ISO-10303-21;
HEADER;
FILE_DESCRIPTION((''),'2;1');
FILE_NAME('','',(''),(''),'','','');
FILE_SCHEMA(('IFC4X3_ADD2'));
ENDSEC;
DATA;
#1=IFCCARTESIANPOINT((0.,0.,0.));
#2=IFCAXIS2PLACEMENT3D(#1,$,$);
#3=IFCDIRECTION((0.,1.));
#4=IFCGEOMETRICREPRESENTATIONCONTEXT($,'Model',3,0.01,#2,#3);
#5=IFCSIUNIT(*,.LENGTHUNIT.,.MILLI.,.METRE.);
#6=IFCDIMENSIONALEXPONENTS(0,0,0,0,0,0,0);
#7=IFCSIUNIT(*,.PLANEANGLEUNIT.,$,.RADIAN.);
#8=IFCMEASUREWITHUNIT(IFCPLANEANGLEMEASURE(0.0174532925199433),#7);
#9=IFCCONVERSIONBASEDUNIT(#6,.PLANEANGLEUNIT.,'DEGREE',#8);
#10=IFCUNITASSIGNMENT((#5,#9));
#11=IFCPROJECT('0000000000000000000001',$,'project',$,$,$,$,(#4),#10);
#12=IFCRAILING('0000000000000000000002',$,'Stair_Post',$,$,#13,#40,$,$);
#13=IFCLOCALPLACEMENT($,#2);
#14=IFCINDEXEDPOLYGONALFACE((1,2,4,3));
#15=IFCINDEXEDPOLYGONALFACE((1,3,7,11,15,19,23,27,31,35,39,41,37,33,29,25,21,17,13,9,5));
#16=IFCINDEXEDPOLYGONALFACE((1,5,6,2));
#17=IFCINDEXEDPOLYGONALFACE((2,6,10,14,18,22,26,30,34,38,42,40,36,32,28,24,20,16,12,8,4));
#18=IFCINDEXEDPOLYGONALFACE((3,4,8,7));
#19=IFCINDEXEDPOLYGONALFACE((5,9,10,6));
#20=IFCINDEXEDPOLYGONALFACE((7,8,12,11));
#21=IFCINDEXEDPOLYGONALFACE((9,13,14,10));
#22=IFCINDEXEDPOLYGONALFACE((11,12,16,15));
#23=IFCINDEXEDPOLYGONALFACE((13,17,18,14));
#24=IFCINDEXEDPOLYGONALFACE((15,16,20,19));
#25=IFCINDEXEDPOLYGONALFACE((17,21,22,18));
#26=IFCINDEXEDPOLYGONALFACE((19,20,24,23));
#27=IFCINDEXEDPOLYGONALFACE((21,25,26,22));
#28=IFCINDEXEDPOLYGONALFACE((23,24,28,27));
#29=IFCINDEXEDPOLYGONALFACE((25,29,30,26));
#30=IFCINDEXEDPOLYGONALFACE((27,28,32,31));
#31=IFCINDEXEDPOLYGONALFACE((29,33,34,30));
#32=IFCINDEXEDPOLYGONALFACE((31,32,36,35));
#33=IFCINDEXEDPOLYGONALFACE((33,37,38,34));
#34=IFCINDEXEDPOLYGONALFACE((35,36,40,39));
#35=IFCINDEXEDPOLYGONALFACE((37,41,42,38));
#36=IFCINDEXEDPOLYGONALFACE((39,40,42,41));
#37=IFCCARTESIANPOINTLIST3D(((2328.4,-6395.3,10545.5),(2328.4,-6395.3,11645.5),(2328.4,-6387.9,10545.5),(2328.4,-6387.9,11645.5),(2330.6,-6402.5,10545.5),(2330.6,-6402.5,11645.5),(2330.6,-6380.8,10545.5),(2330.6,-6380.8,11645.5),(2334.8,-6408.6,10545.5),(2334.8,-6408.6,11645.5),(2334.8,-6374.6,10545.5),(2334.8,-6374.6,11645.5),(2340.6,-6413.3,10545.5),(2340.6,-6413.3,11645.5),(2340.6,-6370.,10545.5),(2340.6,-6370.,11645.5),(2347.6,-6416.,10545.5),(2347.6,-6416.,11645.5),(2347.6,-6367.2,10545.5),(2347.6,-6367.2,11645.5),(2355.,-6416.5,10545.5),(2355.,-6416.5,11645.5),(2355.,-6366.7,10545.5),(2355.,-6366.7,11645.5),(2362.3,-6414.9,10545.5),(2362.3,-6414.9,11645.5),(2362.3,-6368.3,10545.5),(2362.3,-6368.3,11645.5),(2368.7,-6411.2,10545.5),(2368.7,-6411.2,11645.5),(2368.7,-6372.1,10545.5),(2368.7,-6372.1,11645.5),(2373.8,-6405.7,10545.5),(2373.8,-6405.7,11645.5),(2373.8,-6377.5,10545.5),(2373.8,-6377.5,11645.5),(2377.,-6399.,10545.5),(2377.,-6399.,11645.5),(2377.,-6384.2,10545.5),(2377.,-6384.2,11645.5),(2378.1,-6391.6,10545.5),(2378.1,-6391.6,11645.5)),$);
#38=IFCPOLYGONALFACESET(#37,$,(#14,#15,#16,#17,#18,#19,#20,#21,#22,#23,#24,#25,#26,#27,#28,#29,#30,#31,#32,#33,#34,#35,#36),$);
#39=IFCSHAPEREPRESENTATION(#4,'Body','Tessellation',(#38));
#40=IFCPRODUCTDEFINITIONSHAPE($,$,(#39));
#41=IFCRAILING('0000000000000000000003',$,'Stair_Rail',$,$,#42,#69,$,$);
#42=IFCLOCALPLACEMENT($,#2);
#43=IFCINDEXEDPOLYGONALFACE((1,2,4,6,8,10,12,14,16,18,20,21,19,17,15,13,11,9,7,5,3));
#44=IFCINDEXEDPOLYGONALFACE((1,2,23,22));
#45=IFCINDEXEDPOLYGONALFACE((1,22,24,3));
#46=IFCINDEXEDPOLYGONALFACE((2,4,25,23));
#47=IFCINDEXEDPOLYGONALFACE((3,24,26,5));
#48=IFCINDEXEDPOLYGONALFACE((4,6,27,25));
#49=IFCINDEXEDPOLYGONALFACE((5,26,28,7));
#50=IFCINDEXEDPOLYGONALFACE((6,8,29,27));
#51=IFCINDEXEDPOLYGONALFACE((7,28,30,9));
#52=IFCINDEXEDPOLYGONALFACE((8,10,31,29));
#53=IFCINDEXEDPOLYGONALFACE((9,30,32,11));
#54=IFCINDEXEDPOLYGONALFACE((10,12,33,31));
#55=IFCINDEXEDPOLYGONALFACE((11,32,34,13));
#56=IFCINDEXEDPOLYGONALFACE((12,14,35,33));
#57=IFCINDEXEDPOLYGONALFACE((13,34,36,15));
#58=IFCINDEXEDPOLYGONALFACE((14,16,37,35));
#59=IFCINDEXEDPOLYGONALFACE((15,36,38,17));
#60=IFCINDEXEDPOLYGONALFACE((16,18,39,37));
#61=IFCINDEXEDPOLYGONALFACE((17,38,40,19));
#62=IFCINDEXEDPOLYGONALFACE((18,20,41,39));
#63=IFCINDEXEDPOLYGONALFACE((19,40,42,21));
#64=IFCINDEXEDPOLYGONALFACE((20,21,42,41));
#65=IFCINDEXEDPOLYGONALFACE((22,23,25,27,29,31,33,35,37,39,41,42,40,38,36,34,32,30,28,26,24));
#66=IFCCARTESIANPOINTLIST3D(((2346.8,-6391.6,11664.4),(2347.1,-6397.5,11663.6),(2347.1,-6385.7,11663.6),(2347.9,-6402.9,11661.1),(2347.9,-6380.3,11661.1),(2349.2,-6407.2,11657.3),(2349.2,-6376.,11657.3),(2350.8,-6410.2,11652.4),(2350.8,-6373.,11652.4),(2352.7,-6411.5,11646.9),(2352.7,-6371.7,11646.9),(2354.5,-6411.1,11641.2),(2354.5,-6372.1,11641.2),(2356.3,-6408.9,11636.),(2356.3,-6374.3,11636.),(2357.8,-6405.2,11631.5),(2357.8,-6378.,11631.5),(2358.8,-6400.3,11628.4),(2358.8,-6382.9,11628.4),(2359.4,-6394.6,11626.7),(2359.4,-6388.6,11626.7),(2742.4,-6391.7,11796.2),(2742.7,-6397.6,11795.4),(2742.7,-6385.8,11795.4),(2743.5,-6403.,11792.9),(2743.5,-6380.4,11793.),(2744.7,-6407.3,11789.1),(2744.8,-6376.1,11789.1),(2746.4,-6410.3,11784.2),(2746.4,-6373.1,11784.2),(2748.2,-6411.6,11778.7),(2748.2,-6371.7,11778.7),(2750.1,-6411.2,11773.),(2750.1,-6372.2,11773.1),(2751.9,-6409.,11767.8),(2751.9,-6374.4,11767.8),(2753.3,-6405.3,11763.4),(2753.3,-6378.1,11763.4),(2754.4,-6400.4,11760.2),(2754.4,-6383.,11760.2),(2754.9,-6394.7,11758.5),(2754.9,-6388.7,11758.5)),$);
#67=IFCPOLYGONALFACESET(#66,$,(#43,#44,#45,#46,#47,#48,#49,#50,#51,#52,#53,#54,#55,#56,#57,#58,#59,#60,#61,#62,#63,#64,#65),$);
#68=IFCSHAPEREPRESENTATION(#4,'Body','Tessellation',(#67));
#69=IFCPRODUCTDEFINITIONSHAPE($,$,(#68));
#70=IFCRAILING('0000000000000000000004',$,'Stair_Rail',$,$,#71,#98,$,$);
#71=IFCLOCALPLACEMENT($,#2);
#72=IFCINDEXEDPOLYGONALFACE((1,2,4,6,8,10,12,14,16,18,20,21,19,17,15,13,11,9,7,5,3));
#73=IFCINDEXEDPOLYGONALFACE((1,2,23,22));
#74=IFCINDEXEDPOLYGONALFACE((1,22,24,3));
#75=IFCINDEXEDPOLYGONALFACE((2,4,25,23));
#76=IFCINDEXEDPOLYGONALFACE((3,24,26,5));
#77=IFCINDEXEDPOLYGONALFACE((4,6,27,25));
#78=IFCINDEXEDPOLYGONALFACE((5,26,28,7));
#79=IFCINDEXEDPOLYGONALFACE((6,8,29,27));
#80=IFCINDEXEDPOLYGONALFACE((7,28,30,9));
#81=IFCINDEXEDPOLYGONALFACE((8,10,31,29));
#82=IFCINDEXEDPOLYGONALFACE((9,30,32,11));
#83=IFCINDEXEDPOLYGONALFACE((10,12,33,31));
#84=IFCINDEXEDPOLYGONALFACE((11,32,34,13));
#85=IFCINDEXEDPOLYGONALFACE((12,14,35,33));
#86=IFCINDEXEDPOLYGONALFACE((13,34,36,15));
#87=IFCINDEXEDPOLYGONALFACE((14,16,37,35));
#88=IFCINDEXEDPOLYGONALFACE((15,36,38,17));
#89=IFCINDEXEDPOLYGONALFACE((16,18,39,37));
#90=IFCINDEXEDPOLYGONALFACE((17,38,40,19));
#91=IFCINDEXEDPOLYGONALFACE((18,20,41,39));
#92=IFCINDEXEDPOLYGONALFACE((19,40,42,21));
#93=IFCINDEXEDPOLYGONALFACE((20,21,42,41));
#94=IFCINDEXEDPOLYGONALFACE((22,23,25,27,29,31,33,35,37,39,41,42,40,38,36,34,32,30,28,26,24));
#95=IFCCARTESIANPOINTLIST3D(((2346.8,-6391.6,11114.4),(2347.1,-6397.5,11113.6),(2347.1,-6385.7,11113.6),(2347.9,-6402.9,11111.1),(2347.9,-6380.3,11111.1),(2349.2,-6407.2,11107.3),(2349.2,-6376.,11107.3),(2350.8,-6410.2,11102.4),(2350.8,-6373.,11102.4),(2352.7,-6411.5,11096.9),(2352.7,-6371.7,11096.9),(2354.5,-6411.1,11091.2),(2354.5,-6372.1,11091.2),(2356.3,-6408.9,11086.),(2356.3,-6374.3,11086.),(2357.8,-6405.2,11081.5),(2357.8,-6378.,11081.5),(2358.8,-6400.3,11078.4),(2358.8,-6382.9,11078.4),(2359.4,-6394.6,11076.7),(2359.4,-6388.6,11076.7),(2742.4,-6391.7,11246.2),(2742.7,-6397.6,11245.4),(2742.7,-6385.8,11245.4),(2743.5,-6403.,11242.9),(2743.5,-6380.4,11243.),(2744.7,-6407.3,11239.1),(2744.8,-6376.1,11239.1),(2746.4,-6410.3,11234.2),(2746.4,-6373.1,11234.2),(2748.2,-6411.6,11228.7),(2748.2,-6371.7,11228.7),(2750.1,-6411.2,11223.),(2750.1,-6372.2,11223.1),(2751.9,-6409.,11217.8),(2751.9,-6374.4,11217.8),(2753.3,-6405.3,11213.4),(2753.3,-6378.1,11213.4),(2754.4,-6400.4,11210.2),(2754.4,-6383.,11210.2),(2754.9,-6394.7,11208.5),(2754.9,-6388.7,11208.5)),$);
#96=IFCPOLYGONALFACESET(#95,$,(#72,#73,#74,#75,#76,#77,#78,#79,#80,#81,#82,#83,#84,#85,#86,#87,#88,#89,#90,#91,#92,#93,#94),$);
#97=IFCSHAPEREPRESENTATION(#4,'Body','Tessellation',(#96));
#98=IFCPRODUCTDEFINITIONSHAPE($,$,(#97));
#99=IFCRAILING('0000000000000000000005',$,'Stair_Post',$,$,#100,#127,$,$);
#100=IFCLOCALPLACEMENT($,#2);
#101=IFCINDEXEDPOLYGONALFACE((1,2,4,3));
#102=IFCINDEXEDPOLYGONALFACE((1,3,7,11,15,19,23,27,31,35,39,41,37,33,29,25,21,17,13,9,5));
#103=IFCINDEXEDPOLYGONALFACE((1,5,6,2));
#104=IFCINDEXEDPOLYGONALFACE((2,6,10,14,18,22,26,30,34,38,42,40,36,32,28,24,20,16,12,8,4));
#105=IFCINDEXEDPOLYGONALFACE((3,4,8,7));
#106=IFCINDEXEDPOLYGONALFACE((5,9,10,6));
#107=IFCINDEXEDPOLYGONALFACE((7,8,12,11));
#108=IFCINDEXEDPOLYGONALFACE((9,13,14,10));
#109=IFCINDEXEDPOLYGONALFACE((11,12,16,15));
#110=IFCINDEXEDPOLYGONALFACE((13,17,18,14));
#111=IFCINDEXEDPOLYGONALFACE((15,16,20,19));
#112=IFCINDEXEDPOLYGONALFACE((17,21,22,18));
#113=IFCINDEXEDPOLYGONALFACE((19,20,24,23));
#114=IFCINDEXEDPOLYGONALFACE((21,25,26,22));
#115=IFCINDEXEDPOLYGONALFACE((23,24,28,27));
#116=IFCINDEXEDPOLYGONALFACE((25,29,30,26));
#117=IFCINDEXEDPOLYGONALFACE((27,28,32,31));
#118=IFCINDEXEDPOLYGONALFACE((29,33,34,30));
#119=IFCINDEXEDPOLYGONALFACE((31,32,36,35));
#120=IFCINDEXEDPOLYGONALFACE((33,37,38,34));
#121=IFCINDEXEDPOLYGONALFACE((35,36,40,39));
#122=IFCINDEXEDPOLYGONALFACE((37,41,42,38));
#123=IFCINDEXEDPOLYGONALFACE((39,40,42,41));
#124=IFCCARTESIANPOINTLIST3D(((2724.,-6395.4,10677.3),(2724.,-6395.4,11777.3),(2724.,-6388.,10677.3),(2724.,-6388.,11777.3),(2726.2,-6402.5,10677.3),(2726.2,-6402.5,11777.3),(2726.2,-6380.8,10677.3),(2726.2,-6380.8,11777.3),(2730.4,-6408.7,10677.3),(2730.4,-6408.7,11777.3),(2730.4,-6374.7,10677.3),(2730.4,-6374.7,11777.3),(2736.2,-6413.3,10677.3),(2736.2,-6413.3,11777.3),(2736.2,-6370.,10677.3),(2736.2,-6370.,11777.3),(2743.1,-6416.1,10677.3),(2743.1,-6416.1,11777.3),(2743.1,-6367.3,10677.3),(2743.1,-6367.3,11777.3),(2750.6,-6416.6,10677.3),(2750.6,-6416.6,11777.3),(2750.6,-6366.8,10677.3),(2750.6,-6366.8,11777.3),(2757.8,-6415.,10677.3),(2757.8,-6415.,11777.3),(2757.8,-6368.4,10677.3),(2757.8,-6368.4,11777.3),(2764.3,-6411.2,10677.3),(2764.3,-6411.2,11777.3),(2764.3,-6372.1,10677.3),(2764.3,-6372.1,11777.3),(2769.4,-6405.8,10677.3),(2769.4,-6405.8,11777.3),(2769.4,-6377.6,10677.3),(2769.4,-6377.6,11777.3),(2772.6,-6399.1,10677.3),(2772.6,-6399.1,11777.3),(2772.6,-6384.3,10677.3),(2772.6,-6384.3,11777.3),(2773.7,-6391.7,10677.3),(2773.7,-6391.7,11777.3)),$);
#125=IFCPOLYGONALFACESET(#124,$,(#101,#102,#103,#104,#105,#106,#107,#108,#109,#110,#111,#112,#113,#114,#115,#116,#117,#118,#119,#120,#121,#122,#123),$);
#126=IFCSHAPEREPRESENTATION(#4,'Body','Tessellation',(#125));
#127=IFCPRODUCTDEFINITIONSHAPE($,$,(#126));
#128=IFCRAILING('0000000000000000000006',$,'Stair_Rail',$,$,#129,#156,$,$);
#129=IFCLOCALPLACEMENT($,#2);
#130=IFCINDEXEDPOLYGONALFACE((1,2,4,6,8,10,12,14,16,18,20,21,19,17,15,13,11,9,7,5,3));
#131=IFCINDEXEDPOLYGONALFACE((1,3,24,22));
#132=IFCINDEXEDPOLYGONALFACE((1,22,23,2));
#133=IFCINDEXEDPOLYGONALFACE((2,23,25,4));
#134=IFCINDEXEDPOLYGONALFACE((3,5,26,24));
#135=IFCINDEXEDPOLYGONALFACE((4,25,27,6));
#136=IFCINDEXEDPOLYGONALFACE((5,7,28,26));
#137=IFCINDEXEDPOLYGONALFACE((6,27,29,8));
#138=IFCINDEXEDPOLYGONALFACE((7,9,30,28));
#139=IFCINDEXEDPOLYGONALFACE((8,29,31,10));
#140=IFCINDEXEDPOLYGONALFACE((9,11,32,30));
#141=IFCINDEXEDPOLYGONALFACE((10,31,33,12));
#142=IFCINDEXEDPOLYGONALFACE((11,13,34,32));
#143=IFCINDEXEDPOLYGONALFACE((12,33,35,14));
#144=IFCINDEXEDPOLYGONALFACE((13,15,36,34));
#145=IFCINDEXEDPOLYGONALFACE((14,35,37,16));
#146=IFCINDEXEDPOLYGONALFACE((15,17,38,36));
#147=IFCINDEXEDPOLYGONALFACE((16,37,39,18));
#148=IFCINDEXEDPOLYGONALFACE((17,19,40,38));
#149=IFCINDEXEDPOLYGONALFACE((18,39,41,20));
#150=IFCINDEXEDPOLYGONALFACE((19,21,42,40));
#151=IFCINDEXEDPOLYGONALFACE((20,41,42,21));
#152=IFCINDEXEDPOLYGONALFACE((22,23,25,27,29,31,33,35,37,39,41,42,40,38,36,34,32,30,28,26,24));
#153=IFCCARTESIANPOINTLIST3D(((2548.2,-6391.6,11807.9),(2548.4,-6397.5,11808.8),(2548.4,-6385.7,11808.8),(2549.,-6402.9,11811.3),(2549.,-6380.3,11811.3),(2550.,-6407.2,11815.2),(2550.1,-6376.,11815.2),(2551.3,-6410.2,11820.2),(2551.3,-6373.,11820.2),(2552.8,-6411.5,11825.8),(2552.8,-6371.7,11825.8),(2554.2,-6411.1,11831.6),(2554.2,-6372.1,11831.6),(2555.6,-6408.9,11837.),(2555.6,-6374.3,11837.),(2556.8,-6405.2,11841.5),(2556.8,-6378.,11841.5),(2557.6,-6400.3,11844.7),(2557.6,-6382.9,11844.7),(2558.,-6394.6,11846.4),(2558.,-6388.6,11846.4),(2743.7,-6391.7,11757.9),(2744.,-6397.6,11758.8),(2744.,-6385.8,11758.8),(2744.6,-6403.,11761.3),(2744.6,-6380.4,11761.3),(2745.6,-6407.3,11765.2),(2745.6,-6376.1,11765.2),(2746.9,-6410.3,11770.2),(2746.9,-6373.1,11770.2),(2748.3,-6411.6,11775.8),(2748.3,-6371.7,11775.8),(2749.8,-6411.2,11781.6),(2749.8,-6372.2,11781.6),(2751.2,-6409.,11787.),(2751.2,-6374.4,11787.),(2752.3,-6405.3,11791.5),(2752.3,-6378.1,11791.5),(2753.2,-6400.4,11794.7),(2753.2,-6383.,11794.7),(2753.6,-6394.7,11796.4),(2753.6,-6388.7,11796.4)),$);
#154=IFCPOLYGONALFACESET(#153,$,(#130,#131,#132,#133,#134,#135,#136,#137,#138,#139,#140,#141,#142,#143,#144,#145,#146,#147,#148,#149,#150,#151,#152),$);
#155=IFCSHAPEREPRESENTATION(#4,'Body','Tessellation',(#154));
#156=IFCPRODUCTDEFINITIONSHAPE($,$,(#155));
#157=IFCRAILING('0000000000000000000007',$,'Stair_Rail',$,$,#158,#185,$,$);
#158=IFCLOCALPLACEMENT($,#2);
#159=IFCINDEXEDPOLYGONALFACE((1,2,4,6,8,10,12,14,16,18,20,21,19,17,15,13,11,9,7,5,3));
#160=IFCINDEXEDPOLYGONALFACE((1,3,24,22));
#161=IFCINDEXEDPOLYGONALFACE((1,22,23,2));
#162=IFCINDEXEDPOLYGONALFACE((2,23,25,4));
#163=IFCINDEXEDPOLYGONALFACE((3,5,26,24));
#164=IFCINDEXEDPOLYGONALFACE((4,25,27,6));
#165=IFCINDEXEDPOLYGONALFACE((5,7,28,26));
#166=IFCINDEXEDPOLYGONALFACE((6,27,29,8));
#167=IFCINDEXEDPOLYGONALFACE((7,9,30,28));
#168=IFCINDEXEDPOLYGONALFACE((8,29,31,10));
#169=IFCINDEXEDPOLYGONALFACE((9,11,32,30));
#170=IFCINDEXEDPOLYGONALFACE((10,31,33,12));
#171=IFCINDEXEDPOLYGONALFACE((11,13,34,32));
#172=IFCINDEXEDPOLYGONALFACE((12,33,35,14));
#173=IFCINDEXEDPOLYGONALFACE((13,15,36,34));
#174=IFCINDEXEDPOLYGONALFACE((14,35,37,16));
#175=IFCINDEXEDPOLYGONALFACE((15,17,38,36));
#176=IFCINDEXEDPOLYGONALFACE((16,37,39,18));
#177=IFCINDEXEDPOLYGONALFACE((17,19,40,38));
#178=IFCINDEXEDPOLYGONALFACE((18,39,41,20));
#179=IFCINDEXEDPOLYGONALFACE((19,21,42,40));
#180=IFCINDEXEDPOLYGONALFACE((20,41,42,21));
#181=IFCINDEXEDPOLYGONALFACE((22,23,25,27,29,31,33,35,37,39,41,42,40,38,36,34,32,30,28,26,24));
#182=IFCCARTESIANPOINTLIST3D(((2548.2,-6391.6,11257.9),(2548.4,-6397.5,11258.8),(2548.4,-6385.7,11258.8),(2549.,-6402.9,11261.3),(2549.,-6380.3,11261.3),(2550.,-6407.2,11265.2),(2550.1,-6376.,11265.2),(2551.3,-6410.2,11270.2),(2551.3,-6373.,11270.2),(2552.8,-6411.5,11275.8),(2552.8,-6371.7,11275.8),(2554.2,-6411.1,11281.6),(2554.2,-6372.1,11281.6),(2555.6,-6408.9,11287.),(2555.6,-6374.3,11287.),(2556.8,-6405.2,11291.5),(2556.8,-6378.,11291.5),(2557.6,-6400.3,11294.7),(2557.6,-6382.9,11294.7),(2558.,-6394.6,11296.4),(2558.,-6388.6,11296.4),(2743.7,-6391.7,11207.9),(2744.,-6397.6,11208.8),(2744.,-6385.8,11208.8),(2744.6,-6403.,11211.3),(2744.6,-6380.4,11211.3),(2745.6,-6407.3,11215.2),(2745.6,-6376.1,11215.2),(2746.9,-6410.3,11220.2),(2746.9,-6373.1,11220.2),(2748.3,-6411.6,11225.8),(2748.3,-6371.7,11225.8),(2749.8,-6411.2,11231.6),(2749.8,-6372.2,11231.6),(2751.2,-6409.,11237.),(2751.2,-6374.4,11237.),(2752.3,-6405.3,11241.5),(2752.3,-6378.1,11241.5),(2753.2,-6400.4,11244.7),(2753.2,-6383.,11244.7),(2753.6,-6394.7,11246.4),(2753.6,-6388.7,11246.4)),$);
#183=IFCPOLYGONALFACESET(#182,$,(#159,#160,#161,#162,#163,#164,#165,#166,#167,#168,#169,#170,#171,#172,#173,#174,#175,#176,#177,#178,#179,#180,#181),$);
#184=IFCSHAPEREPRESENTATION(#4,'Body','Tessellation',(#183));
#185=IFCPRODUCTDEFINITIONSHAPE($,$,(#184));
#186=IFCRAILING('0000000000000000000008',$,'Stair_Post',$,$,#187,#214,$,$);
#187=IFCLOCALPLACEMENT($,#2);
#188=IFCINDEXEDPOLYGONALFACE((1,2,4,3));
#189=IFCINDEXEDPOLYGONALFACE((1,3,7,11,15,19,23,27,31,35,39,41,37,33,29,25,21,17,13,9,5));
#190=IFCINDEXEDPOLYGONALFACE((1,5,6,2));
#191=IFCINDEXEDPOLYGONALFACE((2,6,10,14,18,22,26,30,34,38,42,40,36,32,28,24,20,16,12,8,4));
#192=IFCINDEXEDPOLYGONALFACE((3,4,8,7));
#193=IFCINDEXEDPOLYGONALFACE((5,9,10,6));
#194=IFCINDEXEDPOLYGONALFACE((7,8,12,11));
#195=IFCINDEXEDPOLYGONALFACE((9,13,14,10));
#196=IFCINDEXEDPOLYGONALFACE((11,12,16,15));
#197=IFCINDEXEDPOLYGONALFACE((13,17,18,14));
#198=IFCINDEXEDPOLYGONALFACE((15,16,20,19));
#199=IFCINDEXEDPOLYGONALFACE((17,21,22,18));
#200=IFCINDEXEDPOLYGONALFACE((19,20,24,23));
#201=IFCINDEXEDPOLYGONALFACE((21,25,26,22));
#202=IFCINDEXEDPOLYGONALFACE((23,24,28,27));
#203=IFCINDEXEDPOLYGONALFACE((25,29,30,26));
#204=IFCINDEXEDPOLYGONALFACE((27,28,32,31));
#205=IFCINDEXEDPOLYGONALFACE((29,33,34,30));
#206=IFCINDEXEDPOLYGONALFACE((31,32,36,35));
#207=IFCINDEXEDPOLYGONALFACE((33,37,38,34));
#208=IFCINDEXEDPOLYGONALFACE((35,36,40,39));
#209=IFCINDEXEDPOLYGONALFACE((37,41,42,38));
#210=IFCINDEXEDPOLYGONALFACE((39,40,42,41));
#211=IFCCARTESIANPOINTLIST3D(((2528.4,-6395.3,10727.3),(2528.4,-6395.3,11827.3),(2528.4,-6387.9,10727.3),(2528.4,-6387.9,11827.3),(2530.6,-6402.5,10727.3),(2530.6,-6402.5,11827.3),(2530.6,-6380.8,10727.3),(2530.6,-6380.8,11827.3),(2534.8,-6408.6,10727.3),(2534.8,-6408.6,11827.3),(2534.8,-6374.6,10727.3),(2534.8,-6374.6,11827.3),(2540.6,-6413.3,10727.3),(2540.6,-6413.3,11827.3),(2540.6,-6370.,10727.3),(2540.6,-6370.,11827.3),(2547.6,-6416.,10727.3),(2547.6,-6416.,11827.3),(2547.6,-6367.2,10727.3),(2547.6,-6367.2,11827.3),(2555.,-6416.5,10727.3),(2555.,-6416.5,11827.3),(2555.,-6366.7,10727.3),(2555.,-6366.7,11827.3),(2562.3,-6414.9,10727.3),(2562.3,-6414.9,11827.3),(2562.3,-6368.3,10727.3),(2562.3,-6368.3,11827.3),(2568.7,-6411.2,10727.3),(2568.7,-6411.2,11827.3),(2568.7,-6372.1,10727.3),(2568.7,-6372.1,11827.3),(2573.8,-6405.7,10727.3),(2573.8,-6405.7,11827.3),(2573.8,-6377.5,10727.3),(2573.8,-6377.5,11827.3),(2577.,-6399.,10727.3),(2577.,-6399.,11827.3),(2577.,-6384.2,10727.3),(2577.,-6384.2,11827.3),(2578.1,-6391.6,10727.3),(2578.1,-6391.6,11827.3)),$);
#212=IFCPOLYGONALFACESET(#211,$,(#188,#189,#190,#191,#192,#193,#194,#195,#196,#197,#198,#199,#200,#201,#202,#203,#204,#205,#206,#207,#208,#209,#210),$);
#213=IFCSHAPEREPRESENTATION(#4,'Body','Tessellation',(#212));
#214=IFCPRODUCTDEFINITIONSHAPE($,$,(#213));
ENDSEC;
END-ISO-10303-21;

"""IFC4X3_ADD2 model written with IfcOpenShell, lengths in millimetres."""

from ifc_helpers import new_model, entity, si_unit, converted_unit, direction, frame, origin, context, project, circle, extrude, element, save


model = new_model("IFC4X3_ADD2")

# Units and contexts
model_context = context("Model", 3, precision=0.01, world=origin(), true_north=direction((0.0, 1.0)))
ifc_project = project(units=[si_unit("LENGTHUNIT", "METRE", prefix="MILLI"), converted_unit("PLANEANGLEUNIT", "DEGREE", entity("IfcPlaneAngleMeasure", 0.0174532925199433), si_unit("PLANEANGLEUNIT", "RADIAN"), dimensions=[0, 0, 0, 0, 0, 0, 0])], contexts=[model_context])

# Railings
element("IfcRailing", 1, Name="Stair_Post", context=model_context, shape_type="SweptSolid", body=[
    extrude(circle(Radius=25.0), frame((2353.1, -6391.6, 10545.5)), (0.0, 0.0, 1.0), 1100.0),
])
element("IfcRailing", 2, Name="Stair_Rail", context=model_context, shape_type="SweptSolid", body=[
    entity("IfcSweptDiskSolid", entity("IfcPolyline", [entity("IfcCartesianPoint", [2353.1, -6391.6, 11645.5]), entity("IfcCartesianPoint", [2748.7, -6391.7, 11777.3])]), 20.0),
])
element("IfcRailing", 3, Name="Stair_Rail", context=model_context, shape_type="SweptSolid", body=[
    entity("IfcSweptDiskSolid", entity("IfcPolyline", [entity("IfcCartesianPoint", [2353.1, -6391.6, 11095.5]), entity("IfcCartesianPoint", [2748.7, -6391.7, 11227.3])]), 20.0),
])
element("IfcRailing", 4, Name="Stair_Post", context=model_context, shape_type="SweptSolid", body=[
    extrude(circle(Radius=25.0), frame((2748.7, -6391.7, 10677.3)), (0.0, 0.0, 1.0), 1100.0),
])
element("IfcRailing", 5, Name="Stair_Rail", context=model_context, shape_type="SweptSolid", body=[
    entity("IfcSweptDiskSolid", entity("IfcPolyline", [entity("IfcCartesianPoint", [2748.7, -6391.7, 11777.3]), entity("IfcCartesianPoint", [2553.1, -6391.6, 11827.3])]), 20.0),
])
element("IfcRailing", 6, Name="Stair_Rail", context=model_context, shape_type="SweptSolid", body=[
    entity("IfcSweptDiskSolid", entity("IfcPolyline", [entity("IfcCartesianPoint", [2748.7, -6391.7, 11227.3]), entity("IfcCartesianPoint", [2553.1, -6391.6, 11277.3])]), 20.0),
])
element("IfcRailing", 7, Name="Stair_Post", context=model_context, shape_type="SweptSolid", body=[
    extrude(circle(Radius=25.0), frame((2553.1, -6391.6, 10727.3)), (0.0, 0.0, 1.0), 1100.0),
])

save(model, "model.ifc")
